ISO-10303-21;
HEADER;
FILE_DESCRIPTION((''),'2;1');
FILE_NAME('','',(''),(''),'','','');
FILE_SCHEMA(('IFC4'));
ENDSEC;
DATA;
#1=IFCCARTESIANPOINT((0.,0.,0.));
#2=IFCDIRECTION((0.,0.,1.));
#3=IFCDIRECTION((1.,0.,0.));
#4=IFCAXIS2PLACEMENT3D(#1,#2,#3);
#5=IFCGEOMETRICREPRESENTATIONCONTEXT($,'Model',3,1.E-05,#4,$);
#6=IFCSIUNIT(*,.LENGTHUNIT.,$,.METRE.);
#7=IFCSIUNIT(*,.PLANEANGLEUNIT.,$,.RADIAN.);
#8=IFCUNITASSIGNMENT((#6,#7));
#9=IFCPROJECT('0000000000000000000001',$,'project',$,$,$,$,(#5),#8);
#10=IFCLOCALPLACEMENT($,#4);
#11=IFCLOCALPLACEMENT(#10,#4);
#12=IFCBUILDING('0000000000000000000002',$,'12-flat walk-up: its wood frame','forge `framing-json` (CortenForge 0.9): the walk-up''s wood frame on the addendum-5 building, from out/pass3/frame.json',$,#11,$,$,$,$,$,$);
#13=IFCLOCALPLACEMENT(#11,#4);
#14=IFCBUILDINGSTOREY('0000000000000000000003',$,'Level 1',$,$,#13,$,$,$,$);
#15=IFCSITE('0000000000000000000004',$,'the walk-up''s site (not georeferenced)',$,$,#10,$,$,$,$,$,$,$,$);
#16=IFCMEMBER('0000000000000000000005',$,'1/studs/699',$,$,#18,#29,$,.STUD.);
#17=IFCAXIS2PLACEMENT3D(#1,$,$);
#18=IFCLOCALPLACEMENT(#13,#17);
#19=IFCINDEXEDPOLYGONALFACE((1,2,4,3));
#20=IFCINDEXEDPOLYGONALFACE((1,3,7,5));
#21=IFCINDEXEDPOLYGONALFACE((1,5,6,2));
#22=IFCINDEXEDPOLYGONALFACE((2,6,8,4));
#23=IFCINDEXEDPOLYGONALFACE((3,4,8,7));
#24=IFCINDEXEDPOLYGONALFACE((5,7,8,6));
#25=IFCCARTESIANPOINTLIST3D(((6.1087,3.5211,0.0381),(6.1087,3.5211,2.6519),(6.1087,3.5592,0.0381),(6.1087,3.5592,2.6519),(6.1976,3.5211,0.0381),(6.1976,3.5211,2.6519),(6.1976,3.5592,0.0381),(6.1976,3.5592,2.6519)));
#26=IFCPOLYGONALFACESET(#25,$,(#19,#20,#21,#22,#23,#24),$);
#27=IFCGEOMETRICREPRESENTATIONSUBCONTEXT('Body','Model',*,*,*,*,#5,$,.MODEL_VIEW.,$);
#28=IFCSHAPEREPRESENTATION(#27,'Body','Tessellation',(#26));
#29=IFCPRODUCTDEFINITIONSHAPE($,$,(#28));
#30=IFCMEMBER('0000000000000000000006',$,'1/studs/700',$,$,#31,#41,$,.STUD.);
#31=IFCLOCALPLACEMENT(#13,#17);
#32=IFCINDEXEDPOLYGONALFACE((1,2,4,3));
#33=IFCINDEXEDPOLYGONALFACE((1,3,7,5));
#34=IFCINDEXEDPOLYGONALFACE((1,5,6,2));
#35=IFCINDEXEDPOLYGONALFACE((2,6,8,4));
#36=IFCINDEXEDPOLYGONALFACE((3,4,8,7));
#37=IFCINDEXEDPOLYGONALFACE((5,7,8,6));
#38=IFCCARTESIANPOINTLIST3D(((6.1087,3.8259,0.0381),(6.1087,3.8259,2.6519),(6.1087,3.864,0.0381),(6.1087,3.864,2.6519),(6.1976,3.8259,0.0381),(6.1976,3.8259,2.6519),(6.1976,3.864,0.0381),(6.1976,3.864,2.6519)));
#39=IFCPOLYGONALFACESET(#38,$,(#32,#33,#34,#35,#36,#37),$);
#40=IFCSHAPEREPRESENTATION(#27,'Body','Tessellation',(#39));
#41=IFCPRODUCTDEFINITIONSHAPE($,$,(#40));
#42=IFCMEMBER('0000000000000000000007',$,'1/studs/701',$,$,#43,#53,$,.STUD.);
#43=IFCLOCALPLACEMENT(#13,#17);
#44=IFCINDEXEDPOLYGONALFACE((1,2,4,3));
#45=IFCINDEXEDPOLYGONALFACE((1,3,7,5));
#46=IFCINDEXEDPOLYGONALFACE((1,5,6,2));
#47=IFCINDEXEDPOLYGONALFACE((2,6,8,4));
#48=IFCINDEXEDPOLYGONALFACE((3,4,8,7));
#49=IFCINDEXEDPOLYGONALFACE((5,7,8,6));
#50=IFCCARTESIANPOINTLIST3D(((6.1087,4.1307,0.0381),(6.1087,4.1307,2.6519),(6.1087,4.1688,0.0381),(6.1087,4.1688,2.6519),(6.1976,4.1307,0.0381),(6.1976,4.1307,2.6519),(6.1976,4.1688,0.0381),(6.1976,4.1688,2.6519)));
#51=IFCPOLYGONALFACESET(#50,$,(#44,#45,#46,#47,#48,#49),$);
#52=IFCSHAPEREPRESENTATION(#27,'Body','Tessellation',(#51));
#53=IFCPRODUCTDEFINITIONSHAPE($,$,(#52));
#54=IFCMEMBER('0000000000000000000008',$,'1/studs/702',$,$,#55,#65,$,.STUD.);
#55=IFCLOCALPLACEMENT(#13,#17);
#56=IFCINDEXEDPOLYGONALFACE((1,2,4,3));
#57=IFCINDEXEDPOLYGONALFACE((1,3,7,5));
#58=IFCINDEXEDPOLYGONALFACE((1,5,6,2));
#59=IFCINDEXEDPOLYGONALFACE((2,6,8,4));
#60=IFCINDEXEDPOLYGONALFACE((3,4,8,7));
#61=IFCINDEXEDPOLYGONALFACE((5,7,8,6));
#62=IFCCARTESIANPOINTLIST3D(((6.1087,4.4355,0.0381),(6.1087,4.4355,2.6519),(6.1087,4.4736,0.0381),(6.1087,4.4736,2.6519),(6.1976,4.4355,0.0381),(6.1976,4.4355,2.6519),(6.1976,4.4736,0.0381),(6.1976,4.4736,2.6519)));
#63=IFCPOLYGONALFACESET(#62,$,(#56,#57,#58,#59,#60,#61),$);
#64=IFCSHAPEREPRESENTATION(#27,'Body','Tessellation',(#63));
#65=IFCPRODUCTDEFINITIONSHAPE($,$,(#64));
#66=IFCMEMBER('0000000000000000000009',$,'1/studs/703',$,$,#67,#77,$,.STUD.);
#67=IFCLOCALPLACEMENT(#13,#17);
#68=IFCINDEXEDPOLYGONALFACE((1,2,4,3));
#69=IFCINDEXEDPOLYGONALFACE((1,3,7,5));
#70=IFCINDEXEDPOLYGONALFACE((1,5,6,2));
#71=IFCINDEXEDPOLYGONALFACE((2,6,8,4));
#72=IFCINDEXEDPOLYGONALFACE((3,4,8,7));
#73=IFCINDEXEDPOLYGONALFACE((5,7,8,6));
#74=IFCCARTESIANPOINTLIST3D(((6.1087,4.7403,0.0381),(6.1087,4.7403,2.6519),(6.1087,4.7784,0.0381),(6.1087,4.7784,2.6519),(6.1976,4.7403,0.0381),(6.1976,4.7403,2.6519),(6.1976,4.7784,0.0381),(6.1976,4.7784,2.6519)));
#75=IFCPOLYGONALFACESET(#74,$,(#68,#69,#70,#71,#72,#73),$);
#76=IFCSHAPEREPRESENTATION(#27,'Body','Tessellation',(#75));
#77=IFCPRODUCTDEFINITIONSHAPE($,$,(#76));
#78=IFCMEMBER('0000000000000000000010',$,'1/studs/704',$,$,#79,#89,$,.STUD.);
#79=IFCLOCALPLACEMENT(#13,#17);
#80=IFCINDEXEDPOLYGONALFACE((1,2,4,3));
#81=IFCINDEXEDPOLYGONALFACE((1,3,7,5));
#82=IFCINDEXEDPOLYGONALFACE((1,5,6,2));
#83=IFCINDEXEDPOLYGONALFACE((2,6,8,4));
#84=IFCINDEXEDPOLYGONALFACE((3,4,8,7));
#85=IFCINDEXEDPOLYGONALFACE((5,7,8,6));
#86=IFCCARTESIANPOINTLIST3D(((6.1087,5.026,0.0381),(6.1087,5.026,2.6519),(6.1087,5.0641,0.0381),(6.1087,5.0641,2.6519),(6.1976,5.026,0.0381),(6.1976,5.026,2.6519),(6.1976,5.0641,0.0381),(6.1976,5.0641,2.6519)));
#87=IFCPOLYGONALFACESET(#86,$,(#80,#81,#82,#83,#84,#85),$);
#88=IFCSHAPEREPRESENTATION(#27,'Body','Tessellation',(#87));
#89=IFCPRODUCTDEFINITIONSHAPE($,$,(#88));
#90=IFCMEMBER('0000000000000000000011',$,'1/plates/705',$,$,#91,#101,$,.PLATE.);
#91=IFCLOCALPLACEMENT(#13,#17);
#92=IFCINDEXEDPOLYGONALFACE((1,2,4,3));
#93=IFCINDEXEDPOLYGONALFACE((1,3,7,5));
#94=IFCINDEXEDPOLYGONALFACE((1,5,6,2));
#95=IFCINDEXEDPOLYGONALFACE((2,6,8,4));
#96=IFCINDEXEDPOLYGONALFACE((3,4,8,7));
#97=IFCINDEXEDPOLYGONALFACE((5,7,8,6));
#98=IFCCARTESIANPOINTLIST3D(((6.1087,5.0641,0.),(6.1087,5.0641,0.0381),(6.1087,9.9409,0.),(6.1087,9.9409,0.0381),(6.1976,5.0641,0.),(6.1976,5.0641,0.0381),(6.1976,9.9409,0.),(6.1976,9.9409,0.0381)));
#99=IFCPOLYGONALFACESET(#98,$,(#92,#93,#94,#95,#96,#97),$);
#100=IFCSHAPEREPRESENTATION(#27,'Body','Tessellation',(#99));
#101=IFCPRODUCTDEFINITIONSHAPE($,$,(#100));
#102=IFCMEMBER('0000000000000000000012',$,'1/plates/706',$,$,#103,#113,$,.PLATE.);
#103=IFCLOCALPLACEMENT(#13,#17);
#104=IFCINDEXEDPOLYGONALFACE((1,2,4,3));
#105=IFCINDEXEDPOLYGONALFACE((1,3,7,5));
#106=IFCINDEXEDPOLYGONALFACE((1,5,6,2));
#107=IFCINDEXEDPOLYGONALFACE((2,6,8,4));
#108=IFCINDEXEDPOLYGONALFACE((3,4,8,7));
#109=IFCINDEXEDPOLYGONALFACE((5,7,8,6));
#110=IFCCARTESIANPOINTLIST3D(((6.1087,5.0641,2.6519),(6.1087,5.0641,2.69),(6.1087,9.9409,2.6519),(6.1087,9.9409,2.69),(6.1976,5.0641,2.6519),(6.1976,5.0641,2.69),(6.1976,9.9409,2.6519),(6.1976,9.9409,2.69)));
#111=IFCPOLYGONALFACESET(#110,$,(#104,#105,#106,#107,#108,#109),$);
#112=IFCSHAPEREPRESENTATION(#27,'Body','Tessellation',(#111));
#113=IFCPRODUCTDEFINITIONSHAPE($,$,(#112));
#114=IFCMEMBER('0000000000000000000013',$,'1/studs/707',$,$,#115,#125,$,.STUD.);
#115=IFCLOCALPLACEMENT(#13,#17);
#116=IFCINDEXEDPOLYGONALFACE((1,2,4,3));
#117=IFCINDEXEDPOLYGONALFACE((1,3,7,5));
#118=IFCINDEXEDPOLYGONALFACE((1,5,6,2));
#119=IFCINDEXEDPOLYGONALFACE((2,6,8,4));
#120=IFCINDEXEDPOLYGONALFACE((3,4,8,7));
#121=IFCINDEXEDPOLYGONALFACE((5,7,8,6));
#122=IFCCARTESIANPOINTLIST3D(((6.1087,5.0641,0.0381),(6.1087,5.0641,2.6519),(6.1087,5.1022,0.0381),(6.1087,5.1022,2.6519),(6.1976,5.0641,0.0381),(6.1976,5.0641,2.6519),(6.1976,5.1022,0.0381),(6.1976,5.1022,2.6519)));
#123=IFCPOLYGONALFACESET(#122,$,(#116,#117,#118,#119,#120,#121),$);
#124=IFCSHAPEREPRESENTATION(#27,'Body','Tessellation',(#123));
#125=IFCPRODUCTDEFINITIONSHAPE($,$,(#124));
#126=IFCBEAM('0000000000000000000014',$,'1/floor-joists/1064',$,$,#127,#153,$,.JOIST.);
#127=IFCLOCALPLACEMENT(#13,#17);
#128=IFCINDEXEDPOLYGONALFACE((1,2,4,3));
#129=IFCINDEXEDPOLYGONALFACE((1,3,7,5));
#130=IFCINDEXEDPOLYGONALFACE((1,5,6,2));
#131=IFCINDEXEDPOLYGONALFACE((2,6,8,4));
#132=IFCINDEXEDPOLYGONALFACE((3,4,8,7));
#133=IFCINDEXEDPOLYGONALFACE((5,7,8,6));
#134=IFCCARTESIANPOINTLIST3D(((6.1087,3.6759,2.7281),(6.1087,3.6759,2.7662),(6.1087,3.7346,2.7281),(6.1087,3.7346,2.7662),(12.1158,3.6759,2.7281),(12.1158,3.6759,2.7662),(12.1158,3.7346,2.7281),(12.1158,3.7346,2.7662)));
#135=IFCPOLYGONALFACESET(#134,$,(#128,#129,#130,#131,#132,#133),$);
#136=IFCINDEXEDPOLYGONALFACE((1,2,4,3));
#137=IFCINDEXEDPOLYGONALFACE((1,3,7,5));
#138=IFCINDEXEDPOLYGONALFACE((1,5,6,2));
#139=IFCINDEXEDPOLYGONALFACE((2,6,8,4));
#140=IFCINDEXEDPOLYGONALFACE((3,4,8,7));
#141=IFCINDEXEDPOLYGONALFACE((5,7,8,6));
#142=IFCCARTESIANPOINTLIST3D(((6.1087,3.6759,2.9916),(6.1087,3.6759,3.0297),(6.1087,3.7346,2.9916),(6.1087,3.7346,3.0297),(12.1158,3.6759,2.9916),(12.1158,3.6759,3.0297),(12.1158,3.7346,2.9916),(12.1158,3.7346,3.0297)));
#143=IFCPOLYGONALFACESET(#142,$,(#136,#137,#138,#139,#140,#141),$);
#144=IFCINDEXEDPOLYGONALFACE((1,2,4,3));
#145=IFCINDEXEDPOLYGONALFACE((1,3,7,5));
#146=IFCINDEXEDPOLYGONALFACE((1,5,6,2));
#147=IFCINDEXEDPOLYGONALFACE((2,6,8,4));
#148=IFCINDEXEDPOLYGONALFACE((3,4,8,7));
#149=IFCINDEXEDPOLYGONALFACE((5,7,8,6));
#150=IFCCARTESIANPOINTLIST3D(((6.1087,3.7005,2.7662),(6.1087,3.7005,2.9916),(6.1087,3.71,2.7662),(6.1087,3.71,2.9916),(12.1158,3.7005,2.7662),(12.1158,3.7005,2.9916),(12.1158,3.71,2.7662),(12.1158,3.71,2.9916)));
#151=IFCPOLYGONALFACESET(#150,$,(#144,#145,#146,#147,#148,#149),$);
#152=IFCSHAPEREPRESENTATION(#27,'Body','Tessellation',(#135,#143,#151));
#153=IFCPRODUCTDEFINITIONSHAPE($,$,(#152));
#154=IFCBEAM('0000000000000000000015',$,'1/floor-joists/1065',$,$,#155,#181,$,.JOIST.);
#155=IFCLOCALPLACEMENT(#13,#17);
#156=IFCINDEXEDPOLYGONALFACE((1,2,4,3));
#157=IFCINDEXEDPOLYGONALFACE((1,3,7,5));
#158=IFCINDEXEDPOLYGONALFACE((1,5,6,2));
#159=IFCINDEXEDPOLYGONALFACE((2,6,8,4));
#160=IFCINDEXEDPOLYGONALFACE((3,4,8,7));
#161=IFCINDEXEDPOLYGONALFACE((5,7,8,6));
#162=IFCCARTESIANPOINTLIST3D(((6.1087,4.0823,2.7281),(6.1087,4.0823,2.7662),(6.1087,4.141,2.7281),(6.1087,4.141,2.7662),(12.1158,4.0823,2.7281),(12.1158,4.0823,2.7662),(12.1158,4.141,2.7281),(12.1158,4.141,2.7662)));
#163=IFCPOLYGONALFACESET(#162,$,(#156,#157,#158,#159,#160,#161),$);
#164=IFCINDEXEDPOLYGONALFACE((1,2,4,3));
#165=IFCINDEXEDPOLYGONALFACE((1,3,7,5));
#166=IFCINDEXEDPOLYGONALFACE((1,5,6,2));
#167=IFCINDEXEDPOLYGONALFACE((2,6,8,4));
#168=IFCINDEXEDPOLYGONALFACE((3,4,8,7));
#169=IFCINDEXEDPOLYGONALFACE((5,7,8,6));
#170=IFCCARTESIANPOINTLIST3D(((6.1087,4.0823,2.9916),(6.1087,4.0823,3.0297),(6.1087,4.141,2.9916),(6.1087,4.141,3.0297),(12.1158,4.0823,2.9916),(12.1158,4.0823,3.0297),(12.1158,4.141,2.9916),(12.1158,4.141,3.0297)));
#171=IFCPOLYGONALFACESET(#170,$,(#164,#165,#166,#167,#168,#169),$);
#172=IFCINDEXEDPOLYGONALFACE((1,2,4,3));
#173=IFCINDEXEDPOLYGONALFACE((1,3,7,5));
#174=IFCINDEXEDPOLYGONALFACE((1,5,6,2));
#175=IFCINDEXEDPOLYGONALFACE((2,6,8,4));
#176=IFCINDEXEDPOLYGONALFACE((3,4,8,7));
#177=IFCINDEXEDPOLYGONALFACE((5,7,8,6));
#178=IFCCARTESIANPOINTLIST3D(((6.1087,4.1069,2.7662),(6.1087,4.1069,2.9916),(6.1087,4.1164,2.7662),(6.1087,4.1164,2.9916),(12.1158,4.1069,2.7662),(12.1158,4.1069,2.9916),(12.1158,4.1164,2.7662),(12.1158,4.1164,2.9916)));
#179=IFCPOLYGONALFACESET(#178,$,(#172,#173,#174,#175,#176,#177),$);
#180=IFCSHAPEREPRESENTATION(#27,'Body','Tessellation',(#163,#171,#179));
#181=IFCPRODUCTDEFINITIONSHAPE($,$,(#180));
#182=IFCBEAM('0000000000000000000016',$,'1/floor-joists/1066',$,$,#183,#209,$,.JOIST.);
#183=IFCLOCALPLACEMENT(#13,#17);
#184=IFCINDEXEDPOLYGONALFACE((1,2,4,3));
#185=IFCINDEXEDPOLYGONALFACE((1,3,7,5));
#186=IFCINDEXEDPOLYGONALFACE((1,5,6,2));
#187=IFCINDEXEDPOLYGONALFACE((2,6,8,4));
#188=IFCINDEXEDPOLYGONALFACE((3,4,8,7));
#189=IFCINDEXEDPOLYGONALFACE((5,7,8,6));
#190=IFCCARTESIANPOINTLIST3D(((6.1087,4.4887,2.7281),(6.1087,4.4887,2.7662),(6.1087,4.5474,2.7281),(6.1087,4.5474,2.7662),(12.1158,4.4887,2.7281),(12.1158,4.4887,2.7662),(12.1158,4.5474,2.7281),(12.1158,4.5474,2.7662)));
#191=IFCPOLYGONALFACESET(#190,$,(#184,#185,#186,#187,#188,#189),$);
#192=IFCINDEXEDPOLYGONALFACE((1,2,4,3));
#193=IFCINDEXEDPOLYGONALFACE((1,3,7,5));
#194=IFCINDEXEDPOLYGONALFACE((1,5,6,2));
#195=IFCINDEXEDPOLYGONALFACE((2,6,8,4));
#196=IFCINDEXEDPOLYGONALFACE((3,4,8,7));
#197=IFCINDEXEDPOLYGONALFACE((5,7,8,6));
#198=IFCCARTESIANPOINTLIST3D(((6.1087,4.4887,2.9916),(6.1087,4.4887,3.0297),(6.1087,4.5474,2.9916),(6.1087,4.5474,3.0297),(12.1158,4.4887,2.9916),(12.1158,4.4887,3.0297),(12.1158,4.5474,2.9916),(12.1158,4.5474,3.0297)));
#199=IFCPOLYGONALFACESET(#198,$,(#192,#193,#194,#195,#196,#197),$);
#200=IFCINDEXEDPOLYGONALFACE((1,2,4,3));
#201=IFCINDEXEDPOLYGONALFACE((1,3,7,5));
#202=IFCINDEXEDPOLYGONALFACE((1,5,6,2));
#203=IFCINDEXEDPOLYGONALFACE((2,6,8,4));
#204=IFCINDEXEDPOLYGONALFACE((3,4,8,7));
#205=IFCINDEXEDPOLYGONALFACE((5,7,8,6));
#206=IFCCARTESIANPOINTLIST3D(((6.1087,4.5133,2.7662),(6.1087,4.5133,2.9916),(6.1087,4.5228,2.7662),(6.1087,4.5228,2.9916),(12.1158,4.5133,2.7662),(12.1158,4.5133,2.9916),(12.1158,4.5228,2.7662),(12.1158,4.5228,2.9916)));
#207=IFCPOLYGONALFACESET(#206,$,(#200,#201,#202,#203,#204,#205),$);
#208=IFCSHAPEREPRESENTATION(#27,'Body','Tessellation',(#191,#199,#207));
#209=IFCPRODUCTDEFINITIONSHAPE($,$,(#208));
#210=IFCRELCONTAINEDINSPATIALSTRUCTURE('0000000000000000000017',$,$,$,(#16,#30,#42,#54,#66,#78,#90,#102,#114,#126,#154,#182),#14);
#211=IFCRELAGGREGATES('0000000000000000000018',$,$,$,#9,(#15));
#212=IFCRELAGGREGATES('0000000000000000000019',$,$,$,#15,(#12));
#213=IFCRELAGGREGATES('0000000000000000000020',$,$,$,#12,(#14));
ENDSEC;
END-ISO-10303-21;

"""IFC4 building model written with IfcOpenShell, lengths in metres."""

from ifc_helpers import new_model, si_unit, frame, frame_2d, origin, origin_with_axes, place, context, subcontext, project, spatial, rectangle, extrude, element, save


model = new_model("IFC4")

# Units and contexts
model_context = context("Model", 3, precision=1e-05, world=origin_with_axes())
body_context = subcontext(model_context, "Body", "Model", "MODEL_VIEW")
ifc_project = project(units=[si_unit("LENGTHUNIT", "METRE"), si_unit("PLANEANGLEUNIT", "RADIAN")], contexts=[model_context])

# Site, building, storey
site_placement = place(None, origin_with_axes())
site = spatial("IfcSite", under=ifc_project, at=site_placement, Name="the walk-up's site (not georeferenced)")
building_placement = place(site_placement, origin_with_axes())
building = spatial("IfcBuilding", under=site, at=building_placement, Name="12-flat walk-up: its wood frame", Description="forge `framing-json` (CortenForge 0.9): the walk-up's wood frame on the addendum-5 building, from out/pass3/frame.json")
storey_placement = place(building_placement, origin_with_axes())
storey = spatial("IfcBuildingStorey", under=building, at=storey_placement, Name="Level 1")

# Members
for number, where, z_axis, x_axis, name in (
    (1, (6.1087, 3.5211, 0.0381), (0.0, 0.0, 1.0), (1.0, 0.0, 0.0), "1/studs/699"),
    (2, (6.1087, 3.8259, 0.0381), (0.0, 0.0, 1.0), (1.0, 0.0, 0.0), "1/studs/700"),
    (3, (6.1087, 4.1307, 0.0381), (0.0, 0.0, 1.0), (1.0, 0.0, 0.0), "1/studs/701"),
    (4, (6.1087, 4.4355, 0.0381), (0.0, 0.0, 1.0), (1.0, 0.0, 0.0), "1/studs/702"),
    (5, (6.1087, 4.7403, 0.0381), (0.0, 0.0, 1.0), (1.0, 0.0, 0.0), "1/studs/703"),
    (6, (6.1087, 5.026, 0.0381), (0.0, 0.0, 1.0), (1.0, 0.0, 0.0), "1/studs/704"),
):
    element("IfcMember", number, at=place(storey_placement, frame(where, z_axis=z_axis, x_axis=x_axis)), inside=storey, Name=name, PredefinedType="STUD", context=body_context, shape_type="SweptSolid", body=[
        extrude(rectangle(XDim=0.0889, YDim=0.0381, at=frame_2d((0.0445, 0.0191))), origin(), (0.0, 0.0, 1.0), 2.6138),
    ])
member_1_placement = place(storey_placement, frame((6.1087, 5.0641, 0.0), z_axis=(0.0, 0.0, 1.0), x_axis=(1.0, 0.0, 0.0)))
element("IfcMember", 7, at=member_1_placement, inside=storey, Name="1/plates/705", PredefinedType="PLATE", context=body_context, shape_type="SweptSolid", body=[
    extrude(rectangle(XDim=0.0889, YDim=4.8768, at=frame_2d((0.0445, 2.4384))), origin(), (0.0, 0.0, 1.0), 0.0381),
])
member_2_placement = place(storey_placement, frame((6.1087, 5.0641, 2.6519), z_axis=(0.0, 0.0, 1.0), x_axis=(1.0, 0.0, 0.0)))
element("IfcMember", 8, at=member_2_placement, inside=storey, Name="1/plates/706", PredefinedType="PLATE", context=body_context, shape_type="SweptSolid", body=[
    extrude(rectangle(XDim=0.0889, YDim=4.8768, at=frame_2d((0.0445, 2.4384))), origin(), (0.0, 0.0, 1.0), 0.0381),
])
member_3_placement = place(storey_placement, frame((6.1087, 5.0641, 0.0381), z_axis=(0.0, 0.0, 1.0), x_axis=(1.0, 0.0, 0.0)))
element("IfcMember", 9, at=member_3_placement, inside=storey, Name="1/studs/707", PredefinedType="STUD", context=body_context, shape_type="SweptSolid", body=[
    extrude(rectangle(XDim=0.0889, YDim=0.0381, at=frame_2d((0.0445, 0.0191))), origin(), (0.0, 0.0, 1.0), 2.6138),
])

# Beams
beam_1_placement = place(storey_placement, frame((6.1087, 3.6759, 2.7281), z_axis=(0.0, 0.0, 1.0), x_axis=(1.0, 0.0, 0.0)))
element("IfcBeam", 10, at=beam_1_placement, inside=storey, Name="1/floor-joists/1064", PredefinedType="JOIST", context=body_context, shape_type="SweptSolid", body=[
    extrude(rectangle(XDim=6.0071, YDim=0.0587, at=frame_2d((3.0036, 0.0294))), origin(), (0.0, 0.0, 1.0), 0.0381),
    extrude(rectangle(XDim=6.0071, YDim=0.0587, at=frame_2d((3.0036, 0.0294))), frame((0.0, 0.0, 0.2635)), (0.0, 0.0, 1.0), 0.0381),
    extrude(rectangle(XDim=6.0071, YDim=0.0095, at=frame_2d((3.0036, 0.0048))), frame((0.0, 0.0246, 0.0381)), (0.0, 0.0, 1.0), 0.2254),
])
beam_2_placement = place(storey_placement, frame((6.1087, 4.0823, 2.7281), z_axis=(0.0, 0.0, 1.0), x_axis=(1.0, 0.0, 0.0)))
element("IfcBeam", 11, at=beam_2_placement, inside=storey, Name="1/floor-joists/1065", PredefinedType="JOIST", context=body_context, shape_type="SweptSolid", body=[
    extrude(rectangle(XDim=6.0071, YDim=0.0587, at=frame_2d((3.0036, 0.0294))), origin(), (0.0, 0.0, 1.0), 0.0381),
    extrude(rectangle(XDim=6.0071, YDim=0.0587, at=frame_2d((3.0036, 0.0294))), frame((0.0, 0.0, 0.2635)), (0.0, 0.0, 1.0), 0.0381),
    extrude(rectangle(XDim=6.0071, YDim=0.0095, at=frame_2d((3.0036, 0.0048))), frame((0.0, 0.0246, 0.0381)), (0.0, 0.0, 1.0), 0.2254),
])
beam_3_placement = place(storey_placement, frame((6.1087, 4.4887, 2.7281), z_axis=(0.0, 0.0, 1.0), x_axis=(1.0, 0.0, 0.0)))
element("IfcBeam", 12, at=beam_3_placement, inside=storey, Name="1/floor-joists/1066", PredefinedType="JOIST", context=body_context, shape_type="SweptSolid", body=[
    extrude(rectangle(XDim=6.0071, YDim=0.0587, at=frame_2d((3.0036, 0.0294))), origin(), (0.0, 0.0, 1.0), 0.0381),
    extrude(rectangle(XDim=6.0071, YDim=0.0587, at=frame_2d((3.0036, 0.0294))), frame((0.0, 0.0, 0.2635)), (0.0, 0.0, 1.0), 0.0381),
    extrude(rectangle(XDim=6.0071, YDim=0.0095, at=frame_2d((3.0036, 0.0048))), frame((0.0, 0.0246, 0.0381)), (0.0, 0.0, 1.0), 0.2254),
])

save(model, "model.ifc")
